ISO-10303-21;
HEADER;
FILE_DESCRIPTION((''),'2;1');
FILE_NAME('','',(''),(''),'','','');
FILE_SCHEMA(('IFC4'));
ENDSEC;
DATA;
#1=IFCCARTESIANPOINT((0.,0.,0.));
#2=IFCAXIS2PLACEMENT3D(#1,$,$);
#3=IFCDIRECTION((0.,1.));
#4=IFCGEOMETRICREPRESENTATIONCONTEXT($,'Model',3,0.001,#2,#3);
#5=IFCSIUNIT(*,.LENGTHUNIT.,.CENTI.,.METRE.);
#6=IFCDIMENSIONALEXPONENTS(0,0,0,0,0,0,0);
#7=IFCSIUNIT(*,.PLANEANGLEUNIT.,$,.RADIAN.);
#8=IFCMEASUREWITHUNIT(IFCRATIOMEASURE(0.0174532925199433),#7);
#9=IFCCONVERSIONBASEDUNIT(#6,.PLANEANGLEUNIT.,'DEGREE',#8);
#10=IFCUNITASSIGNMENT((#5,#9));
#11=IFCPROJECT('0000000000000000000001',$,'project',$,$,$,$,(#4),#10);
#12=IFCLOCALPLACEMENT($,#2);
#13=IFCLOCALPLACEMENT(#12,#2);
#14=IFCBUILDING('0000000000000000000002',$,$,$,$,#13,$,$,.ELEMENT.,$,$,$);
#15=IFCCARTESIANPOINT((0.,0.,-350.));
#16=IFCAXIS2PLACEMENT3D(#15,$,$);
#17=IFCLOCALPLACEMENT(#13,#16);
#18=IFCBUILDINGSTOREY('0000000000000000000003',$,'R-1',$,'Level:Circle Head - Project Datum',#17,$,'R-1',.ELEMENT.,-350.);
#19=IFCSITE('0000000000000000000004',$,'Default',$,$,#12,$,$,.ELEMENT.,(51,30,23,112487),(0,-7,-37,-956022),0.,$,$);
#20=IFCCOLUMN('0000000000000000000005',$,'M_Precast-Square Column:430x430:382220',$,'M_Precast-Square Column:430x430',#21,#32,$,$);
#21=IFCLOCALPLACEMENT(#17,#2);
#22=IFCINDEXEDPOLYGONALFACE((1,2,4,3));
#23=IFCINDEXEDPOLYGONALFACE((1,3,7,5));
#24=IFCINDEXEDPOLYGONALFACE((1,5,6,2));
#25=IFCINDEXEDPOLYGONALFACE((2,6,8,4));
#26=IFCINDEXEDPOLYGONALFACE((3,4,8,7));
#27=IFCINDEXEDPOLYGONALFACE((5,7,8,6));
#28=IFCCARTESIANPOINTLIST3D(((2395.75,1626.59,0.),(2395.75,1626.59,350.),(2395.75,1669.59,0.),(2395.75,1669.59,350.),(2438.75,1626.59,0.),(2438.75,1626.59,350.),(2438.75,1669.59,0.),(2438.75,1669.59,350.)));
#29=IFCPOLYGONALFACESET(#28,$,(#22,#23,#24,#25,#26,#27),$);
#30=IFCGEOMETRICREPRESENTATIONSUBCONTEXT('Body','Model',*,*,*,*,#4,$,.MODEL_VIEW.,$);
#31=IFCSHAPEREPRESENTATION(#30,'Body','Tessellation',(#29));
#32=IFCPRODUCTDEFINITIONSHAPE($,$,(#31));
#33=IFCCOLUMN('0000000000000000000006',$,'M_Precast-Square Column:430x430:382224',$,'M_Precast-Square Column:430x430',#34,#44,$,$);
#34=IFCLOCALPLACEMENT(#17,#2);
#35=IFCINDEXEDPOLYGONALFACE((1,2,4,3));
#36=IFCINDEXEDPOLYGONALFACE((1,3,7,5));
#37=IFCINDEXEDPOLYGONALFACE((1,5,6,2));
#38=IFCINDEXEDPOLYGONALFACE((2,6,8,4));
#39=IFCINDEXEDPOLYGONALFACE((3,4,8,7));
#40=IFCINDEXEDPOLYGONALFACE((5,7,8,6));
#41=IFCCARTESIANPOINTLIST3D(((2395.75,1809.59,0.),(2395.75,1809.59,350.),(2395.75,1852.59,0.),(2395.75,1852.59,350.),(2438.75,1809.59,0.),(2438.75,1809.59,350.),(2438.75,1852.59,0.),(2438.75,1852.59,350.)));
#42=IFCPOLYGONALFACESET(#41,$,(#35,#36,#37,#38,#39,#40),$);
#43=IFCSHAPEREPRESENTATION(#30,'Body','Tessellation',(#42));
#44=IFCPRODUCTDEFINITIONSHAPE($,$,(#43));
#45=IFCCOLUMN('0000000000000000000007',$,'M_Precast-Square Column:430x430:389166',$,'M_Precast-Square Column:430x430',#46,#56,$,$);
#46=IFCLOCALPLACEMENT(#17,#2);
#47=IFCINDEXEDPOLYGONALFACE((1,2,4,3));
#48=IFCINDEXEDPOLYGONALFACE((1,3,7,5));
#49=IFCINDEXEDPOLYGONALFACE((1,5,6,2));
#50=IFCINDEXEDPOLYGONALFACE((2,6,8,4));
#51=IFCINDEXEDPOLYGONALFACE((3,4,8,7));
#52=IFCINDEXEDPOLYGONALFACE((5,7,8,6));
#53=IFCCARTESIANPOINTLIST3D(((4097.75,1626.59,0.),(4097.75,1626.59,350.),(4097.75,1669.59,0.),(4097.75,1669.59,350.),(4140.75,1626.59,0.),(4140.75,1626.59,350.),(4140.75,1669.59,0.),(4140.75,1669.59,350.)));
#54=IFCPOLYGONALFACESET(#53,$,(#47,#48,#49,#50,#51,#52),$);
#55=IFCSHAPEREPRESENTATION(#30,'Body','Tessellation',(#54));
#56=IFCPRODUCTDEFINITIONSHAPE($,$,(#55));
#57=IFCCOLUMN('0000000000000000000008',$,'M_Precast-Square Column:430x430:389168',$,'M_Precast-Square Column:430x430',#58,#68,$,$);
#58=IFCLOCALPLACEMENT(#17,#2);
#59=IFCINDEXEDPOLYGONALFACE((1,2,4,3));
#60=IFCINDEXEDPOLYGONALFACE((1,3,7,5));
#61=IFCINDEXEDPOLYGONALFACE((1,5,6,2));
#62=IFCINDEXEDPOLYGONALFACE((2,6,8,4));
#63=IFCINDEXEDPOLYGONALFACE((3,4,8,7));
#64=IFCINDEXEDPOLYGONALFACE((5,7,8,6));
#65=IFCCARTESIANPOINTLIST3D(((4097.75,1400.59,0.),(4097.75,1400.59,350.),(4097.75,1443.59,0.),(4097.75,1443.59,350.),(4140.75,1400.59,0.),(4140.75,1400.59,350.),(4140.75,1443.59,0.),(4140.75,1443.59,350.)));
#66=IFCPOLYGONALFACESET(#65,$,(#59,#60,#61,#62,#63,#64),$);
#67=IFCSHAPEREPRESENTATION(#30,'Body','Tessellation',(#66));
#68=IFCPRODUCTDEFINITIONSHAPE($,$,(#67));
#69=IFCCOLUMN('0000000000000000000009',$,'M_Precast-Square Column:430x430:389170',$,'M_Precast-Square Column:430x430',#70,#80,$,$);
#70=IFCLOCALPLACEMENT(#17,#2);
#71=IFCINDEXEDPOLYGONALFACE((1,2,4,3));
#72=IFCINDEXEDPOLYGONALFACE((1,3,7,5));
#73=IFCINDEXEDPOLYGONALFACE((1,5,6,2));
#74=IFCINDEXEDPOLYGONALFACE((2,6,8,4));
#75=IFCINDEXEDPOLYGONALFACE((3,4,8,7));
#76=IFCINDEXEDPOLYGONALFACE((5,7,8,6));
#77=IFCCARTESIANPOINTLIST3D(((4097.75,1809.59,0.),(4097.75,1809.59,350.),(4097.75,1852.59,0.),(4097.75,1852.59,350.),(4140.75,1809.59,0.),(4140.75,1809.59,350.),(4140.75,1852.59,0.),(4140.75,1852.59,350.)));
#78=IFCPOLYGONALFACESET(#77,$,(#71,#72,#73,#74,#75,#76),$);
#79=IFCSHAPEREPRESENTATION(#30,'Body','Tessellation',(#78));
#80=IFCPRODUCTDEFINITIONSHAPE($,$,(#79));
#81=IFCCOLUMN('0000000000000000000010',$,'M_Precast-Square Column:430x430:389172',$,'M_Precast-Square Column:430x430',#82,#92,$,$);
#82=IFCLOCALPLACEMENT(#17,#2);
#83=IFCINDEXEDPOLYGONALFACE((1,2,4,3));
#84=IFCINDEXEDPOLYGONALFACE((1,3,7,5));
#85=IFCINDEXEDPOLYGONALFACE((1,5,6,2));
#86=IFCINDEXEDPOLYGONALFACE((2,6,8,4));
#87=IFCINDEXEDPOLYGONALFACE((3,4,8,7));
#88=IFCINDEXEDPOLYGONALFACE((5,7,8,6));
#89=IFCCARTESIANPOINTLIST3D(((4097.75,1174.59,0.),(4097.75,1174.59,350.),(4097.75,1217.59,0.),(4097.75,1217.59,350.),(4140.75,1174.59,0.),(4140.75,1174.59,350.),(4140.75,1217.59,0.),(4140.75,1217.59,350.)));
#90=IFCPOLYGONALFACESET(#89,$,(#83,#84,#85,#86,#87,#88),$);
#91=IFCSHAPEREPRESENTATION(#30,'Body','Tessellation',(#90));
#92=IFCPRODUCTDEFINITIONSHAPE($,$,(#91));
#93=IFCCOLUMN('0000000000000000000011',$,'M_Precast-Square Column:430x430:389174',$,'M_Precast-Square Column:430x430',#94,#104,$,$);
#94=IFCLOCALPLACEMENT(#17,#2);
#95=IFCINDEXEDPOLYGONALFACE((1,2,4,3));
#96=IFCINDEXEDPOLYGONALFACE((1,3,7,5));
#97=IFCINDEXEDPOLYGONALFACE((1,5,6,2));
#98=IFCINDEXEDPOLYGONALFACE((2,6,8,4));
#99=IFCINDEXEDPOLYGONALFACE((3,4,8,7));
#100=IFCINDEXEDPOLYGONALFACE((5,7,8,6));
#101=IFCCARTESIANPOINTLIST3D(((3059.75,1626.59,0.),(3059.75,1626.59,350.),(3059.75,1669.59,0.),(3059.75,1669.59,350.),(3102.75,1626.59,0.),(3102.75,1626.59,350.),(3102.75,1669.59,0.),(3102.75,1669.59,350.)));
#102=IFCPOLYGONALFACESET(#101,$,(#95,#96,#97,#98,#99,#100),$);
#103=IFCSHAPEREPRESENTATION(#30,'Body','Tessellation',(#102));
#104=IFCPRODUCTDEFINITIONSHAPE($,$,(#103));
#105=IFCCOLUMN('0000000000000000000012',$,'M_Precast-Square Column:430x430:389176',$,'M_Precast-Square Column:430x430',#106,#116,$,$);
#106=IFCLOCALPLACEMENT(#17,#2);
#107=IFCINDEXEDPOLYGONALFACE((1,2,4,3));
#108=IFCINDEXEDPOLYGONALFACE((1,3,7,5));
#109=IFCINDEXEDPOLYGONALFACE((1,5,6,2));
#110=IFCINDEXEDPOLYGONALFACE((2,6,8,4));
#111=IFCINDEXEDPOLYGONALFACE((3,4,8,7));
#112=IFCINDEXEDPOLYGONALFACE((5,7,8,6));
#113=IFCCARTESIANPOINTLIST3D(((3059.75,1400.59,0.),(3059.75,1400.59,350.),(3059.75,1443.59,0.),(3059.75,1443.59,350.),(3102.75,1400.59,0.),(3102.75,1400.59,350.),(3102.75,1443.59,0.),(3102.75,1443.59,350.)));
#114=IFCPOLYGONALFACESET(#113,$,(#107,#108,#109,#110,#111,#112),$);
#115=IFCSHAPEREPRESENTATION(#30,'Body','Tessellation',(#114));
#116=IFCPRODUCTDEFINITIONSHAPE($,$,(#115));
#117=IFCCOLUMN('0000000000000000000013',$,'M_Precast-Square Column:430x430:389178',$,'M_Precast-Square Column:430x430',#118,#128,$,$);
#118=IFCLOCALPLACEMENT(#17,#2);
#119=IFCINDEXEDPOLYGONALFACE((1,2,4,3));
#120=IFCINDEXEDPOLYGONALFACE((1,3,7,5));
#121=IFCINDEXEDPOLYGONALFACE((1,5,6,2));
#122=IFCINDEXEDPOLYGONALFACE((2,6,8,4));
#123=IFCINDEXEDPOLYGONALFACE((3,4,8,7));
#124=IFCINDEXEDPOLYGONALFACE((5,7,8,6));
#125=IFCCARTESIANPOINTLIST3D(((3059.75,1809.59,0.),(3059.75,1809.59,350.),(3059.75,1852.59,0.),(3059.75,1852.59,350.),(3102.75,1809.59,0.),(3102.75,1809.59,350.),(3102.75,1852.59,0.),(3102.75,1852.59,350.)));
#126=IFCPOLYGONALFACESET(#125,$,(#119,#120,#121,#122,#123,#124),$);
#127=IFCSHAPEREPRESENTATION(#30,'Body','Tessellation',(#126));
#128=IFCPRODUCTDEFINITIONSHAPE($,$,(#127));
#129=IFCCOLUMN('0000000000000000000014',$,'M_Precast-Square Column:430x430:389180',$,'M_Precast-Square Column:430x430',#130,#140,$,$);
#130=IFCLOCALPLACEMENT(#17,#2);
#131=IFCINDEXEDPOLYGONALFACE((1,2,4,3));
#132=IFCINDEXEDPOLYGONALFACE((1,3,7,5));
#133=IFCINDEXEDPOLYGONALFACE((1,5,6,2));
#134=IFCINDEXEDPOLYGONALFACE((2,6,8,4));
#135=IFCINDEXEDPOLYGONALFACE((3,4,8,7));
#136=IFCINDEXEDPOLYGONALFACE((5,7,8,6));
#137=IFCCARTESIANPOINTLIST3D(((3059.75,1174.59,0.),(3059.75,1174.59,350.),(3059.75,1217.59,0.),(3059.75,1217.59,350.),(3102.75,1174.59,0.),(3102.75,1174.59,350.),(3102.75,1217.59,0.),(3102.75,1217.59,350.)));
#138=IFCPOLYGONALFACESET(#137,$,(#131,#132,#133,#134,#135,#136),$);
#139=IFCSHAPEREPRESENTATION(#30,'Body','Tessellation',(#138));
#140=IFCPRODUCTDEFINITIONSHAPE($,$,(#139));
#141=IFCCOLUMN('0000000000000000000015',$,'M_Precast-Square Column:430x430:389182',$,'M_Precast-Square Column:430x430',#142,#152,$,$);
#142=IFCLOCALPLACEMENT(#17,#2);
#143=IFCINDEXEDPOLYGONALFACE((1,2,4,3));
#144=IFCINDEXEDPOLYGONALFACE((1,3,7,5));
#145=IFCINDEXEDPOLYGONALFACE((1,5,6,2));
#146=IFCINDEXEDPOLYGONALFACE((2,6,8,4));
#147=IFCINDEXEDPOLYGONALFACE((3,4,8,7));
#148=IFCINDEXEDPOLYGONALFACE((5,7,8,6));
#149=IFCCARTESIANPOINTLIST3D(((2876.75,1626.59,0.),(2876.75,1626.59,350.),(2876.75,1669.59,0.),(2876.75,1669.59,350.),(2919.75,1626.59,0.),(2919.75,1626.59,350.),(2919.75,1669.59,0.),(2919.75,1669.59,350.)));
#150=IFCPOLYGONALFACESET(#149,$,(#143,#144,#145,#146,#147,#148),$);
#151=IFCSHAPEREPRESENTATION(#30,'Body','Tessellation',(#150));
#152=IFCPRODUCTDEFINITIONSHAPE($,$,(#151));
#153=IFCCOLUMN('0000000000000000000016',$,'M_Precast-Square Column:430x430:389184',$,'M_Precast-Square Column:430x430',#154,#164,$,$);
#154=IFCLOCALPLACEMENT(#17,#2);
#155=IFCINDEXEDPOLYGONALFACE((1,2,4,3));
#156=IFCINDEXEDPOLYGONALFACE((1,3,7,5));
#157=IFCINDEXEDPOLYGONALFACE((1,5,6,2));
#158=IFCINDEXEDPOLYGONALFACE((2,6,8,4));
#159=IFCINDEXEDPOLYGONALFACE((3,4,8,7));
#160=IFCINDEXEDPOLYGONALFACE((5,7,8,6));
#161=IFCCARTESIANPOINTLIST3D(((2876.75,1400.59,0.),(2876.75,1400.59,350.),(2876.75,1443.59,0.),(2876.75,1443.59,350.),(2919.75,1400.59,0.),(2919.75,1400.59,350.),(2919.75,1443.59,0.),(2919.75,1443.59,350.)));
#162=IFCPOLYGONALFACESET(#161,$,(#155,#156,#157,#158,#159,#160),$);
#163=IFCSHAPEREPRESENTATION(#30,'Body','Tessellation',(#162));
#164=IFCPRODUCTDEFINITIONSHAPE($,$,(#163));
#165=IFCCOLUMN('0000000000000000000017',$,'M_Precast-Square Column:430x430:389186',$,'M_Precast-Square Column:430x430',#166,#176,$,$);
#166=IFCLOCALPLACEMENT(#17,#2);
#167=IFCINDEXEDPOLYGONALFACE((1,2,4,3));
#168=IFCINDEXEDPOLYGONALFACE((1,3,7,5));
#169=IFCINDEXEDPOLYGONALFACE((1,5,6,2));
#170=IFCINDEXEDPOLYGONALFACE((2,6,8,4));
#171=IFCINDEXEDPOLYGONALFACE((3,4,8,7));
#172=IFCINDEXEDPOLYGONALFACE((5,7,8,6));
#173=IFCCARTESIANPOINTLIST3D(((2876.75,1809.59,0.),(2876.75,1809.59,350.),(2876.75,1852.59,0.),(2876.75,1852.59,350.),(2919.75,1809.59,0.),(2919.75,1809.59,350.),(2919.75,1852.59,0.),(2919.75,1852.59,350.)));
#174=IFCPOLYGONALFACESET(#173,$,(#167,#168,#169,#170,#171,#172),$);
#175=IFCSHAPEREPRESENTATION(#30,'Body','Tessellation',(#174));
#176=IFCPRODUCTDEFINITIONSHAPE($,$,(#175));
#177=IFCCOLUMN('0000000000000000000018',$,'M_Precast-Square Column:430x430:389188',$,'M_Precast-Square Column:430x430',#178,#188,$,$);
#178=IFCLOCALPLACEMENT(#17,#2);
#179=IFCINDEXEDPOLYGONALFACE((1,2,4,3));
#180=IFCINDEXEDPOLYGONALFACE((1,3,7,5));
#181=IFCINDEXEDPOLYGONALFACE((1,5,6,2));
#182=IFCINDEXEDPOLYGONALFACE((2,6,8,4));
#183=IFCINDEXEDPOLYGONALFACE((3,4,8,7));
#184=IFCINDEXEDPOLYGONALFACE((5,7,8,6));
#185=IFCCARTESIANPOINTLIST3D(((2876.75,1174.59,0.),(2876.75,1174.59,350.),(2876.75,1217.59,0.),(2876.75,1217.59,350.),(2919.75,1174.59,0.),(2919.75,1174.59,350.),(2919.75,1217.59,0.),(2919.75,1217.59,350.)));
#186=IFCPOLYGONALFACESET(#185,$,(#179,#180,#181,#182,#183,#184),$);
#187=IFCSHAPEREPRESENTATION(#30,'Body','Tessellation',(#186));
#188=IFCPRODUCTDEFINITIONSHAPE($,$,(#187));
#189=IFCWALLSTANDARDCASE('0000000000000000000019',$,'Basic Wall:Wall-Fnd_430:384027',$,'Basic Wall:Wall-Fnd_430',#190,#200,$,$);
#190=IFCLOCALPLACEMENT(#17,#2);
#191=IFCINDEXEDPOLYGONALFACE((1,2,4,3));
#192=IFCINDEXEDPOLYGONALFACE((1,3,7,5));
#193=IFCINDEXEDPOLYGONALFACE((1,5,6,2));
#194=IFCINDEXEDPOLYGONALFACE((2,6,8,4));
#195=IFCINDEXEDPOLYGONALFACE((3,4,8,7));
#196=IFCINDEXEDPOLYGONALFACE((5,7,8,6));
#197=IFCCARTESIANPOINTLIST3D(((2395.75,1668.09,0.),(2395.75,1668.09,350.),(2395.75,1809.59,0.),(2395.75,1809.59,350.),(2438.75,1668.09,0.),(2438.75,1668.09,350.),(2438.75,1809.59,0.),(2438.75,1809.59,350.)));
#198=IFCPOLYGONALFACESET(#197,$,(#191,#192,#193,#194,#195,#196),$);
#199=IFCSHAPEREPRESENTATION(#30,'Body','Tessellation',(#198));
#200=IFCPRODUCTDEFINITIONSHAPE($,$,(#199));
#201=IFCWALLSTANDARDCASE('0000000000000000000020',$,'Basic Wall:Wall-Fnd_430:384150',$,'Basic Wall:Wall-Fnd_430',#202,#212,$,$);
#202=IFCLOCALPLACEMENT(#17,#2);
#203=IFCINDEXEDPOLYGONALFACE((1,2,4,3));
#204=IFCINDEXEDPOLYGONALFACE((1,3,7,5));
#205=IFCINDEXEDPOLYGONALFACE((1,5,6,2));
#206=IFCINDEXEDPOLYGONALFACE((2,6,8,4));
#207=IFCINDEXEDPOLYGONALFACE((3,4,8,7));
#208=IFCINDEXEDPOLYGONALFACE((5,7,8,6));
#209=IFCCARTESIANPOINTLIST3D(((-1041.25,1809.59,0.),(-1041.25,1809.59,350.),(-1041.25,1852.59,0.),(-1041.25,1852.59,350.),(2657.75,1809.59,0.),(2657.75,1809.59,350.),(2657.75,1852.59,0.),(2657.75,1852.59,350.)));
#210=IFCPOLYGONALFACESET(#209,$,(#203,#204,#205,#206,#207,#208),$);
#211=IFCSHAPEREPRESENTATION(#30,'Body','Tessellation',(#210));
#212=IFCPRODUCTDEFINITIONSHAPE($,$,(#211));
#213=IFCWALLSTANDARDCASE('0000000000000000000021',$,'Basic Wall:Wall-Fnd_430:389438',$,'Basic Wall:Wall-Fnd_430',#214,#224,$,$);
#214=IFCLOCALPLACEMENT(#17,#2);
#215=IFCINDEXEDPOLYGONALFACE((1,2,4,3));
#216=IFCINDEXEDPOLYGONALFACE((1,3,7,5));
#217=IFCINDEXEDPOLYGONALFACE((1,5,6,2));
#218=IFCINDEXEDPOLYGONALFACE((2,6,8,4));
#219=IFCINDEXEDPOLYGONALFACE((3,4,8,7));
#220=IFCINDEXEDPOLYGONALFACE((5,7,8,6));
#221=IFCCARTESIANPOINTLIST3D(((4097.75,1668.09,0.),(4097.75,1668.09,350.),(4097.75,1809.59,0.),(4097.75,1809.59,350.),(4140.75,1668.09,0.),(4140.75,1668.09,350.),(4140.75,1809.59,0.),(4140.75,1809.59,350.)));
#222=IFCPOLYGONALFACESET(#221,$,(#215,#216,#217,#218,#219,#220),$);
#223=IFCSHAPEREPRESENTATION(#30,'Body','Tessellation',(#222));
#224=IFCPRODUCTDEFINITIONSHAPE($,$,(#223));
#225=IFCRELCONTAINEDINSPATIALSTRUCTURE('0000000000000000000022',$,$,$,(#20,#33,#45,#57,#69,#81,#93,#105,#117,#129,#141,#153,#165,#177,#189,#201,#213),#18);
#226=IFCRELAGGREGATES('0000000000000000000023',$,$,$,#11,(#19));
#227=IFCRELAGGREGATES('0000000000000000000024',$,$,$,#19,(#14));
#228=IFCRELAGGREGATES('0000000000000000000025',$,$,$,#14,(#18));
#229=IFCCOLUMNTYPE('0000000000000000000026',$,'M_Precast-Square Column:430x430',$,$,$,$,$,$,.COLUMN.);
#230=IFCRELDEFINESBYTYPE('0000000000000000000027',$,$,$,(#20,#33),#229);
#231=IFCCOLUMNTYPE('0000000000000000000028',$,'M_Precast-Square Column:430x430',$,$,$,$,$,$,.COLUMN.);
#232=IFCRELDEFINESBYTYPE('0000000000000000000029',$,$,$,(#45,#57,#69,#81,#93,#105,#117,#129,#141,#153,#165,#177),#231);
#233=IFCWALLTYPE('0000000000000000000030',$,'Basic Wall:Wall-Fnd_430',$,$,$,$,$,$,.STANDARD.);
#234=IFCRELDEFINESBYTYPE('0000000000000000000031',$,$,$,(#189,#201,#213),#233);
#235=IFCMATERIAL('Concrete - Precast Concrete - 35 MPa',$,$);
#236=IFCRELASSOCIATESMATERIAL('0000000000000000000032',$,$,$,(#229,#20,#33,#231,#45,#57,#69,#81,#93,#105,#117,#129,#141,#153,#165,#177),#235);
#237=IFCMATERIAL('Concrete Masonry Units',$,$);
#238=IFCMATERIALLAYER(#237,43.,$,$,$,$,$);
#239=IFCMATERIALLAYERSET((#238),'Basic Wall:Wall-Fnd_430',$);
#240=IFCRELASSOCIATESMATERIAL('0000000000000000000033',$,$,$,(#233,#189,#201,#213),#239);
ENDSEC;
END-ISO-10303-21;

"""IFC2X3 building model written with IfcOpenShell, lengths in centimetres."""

from ifc_helpers import new_model, entity, si_unit, converted_unit, direction, frame, frame_2d, origin, origin_2d_with_axis, place, context, subcontext, project, spatial, rectangle, extrude, source, transform, mapped, material, layer, layer_set, layer_usage, type_object, type_shapes, element, save


model = new_model("IFC2X3")

# Units and contexts
model_context = context("Model", 3, precision=0.001, world=origin(), true_north=direction((0.0, 1.0)))
body_context = subcontext(model_context, "Body", "Model", "MODEL_VIEW")
ifc_project = project(units=[si_unit("LENGTHUNIT", "METRE", prefix="CENTI"), converted_unit("PLANEANGLEUNIT", "DEGREE", entity("IfcRatioMeasure", 0.0174532925199433), si_unit("PLANEANGLEUNIT", "RADIAN"), dimensions=[0, 0, 0, 0, 0, 0, 0])], contexts=[model_context])

# Site, building, storey
site_placement = place(None, origin())
site = spatial("IfcSite", under=ifc_project, at=site_placement, Name="Default", CompositionType="ELEMENT", RefLatitude=(51, 30, 23, 112487), RefLongitude=(0, -7, -37, -956022), RefElevation=0.0)
building_placement = place(site_placement, origin())
building = spatial("IfcBuilding", under=site, at=building_placement, CompositionType="ELEMENT")
storey_placement = place(building_placement, frame((0.0, 0.0, -350.0)))
storey = spatial("IfcBuildingStorey", under=building, at=storey_placement, Name="R-1", ObjectType="Level:Circle Head - Project Datum", LongName="R-1", CompositionType="ELEMENT", Elevation=-350.0)

# Columns
ifc_material_1 = material(Name="Concrete - Precast Concrete - 35 MPa")
column_type_1 = type_object("IfcColumnType", Name="M_Precast-Square Column:430x430", PredefinedType="COLUMN", material=ifc_material_1)
shared_shape_1 = source(origin(), body_context, "Body", "SweptSolid", [
    extrude(rectangle(XDim=43.0, YDim=43.0, at=origin_2d_with_axis()), frame((0.0, 0.0, -350.0), z_axis=(0.0, 0.0, 1.0), x_axis=(0.0, -1.0, 0.0)), (0.0, 0.0, 1.0), 350.0),
])
type_shapes(column_type_1, [shared_shape_1])
for number, where, z_axis, x_axis, name in (
    (1, (2417.25, 1648.09, 350.0), (0.0, 0.0, 1.0), (-1.0, 0.0, 0.0), "M_Precast-Square Column:430x430:382220"),
    (2, (2417.25, 1831.09, 350.0), (0.0, 0.0, 1.0), (-1.0, 0.0, 0.0), "M_Precast-Square Column:430x430:382224"),
):
    element("IfcColumn", number, at=place(storey_placement, frame(where, z_axis=z_axis, x_axis=x_axis)), inside=storey, type_object=column_type_1, material=ifc_material_1, Name=name, ObjectType="M_Precast-Square Column:430x430", context=body_context, shape_type="MappedRepresentation", body=[
        mapped(shared_shape_1, transform((0.0, 0.0, 0.0), scale=1.0)),
    ])
column_type_2 = type_object("IfcColumnType", Name="M_Precast-Square Column:430x430", PredefinedType="COLUMN", material=ifc_material_1)
shared_shape_2 = source(origin(), body_context, "Body", "SweptSolid", [
    extrude(rectangle(XDim=43.0, YDim=43.0, at=origin_2d_with_axis()), frame((0.0, 0.0, -350.0), z_axis=(0.0, 0.0, 1.0), x_axis=(0.0, -1.0, 0.0)), (0.0, 0.0, 1.0), 350.0),
])
type_shapes(column_type_2, [shared_shape_2])
for number, where, name in (
    (3, (4119.25, 1648.09, 350.0), "M_Precast-Square Column:430x430:389166"),
    (4, (4119.25, 1422.09, 350.0), "M_Precast-Square Column:430x430:389168"),
    (5, (4119.25, 1831.09, 350.0), "M_Precast-Square Column:430x430:389170"),
    (6, (4119.25, 1196.09, 350.0), "M_Precast-Square Column:430x430:389172"),
    (7, (3081.25, 1648.09, 350.0), "M_Precast-Square Column:430x430:389174"),
    (8, (3081.25, 1422.09, 350.0), "M_Precast-Square Column:430x430:389176"),
    (9, (3081.25, 1831.09, 350.0), "M_Precast-Square Column:430x430:389178"),
    (10, (3081.25, 1196.09, 350.0), "M_Precast-Square Column:430x430:389180"),
    (11, (2898.25, 1648.09, 350.0), "M_Precast-Square Column:430x430:389182"),
    (12, (2898.25, 1422.09, 350.0), "M_Precast-Square Column:430x430:389184"),
    (13, (2898.25, 1831.09, 350.0), "M_Precast-Square Column:430x430:389186"),
    (14, (2898.25, 1196.09, 350.0), "M_Precast-Square Column:430x430:389188"),
):
    element("IfcColumn", number, at=place(storey_placement, frame(where)), inside=storey, type_object=column_type_2, material=ifc_material_1, Name=name, ObjectType="M_Precast-Square Column:430x430", context=body_context, shape_type="MappedRepresentation", body=[
        mapped(shared_shape_2, transform((0.0, 0.0, 0.0), scale=1.0)),
    ])

# Walls
ifc_material_2 = material(Name="Concrete Masonry Units")
ifc_layer_1 = layer(ifc_material_2, 43.0)
ifc_layer_set_1 = layer_set([ifc_layer_1], Name="Basic Wall:Wall-Fnd_430")
ifc_layer_usage_1 = layer_usage(ifc_layer_set_1, "AXIS2", "NEGATIVE", 21.5)
wall_type_1 = type_object("IfcWallType", Name="Basic Wall:Wall-Fnd_430", PredefinedType="STANDARD", material=ifc_layer_set_1)
wall_1_placement = place(storey_placement, frame((2417.25, 1809.59, 0.0), z_axis=(0.0, 0.0, 1.0), x_axis=(0.0, -1.0, 0.0)))
element("IfcWallStandardCase", 15, at=wall_1_placement, inside=storey, type_object=wall_type_1, material=ifc_layer_usage_1, Name="Basic Wall:Wall-Fnd_430:384027", ObjectType="Basic Wall:Wall-Fnd_430", context=body_context, shape_type="SweptSolid", body=[
    extrude(rectangle(XDim=141.5, YDim=43.0, at=frame_2d((70.75, 0.0), x_axis=(-1.0, 0.0))), origin(), (0.0, 0.0, 1.0), 350.0),
])
ifc_layer_usage_2 = layer_usage(ifc_layer_set_1, "AXIS2", "NEGATIVE", 21.5)
wall_2_placement = place(storey_placement, frame((2657.75, 1831.09, 0.0), z_axis=(0.0, 0.0, 1.0), x_axis=(-1.0, 0.0, 0.0)))
element("IfcWallStandardCase", 16, at=wall_2_placement, inside=storey, type_object=wall_type_1, material=ifc_layer_usage_2, Name="Basic Wall:Wall-Fnd_430:384150", ObjectType="Basic Wall:Wall-Fnd_430", context=body_context, shape_type="SweptSolid", body=[
    extrude(rectangle(XDim=3699.0, YDim=43.0, at=frame_2d((1849.5, 0.0), x_axis=(-1.0, 0.0))), origin(), (0.0, 0.0, 1.0), 350.0),
])
ifc_layer_usage_3 = layer_usage(ifc_layer_set_1, "AXIS2", "POSITIVE", -21.5)
wall_3_placement = place(storey_placement, frame((4119.25, 1668.09, 0.0), z_axis=(0.0, 0.0, 1.0), x_axis=(0.0, 1.0, 0.0)))
element("IfcWallStandardCase", 17, at=wall_3_placement, inside=storey, type_object=wall_type_1, material=ifc_layer_usage_3, Name="Basic Wall:Wall-Fnd_430:389438", ObjectType="Basic Wall:Wall-Fnd_430", context=body_context, shape_type="SweptSolid", body=[
    extrude(rectangle(XDim=141.5, YDim=43.0, at=frame_2d((70.75, 0.0), x_axis=(-1.0, 0.0))), origin(), (0.0, 0.0, 1.0), 350.0),
])

save(model, "model.ifc")
